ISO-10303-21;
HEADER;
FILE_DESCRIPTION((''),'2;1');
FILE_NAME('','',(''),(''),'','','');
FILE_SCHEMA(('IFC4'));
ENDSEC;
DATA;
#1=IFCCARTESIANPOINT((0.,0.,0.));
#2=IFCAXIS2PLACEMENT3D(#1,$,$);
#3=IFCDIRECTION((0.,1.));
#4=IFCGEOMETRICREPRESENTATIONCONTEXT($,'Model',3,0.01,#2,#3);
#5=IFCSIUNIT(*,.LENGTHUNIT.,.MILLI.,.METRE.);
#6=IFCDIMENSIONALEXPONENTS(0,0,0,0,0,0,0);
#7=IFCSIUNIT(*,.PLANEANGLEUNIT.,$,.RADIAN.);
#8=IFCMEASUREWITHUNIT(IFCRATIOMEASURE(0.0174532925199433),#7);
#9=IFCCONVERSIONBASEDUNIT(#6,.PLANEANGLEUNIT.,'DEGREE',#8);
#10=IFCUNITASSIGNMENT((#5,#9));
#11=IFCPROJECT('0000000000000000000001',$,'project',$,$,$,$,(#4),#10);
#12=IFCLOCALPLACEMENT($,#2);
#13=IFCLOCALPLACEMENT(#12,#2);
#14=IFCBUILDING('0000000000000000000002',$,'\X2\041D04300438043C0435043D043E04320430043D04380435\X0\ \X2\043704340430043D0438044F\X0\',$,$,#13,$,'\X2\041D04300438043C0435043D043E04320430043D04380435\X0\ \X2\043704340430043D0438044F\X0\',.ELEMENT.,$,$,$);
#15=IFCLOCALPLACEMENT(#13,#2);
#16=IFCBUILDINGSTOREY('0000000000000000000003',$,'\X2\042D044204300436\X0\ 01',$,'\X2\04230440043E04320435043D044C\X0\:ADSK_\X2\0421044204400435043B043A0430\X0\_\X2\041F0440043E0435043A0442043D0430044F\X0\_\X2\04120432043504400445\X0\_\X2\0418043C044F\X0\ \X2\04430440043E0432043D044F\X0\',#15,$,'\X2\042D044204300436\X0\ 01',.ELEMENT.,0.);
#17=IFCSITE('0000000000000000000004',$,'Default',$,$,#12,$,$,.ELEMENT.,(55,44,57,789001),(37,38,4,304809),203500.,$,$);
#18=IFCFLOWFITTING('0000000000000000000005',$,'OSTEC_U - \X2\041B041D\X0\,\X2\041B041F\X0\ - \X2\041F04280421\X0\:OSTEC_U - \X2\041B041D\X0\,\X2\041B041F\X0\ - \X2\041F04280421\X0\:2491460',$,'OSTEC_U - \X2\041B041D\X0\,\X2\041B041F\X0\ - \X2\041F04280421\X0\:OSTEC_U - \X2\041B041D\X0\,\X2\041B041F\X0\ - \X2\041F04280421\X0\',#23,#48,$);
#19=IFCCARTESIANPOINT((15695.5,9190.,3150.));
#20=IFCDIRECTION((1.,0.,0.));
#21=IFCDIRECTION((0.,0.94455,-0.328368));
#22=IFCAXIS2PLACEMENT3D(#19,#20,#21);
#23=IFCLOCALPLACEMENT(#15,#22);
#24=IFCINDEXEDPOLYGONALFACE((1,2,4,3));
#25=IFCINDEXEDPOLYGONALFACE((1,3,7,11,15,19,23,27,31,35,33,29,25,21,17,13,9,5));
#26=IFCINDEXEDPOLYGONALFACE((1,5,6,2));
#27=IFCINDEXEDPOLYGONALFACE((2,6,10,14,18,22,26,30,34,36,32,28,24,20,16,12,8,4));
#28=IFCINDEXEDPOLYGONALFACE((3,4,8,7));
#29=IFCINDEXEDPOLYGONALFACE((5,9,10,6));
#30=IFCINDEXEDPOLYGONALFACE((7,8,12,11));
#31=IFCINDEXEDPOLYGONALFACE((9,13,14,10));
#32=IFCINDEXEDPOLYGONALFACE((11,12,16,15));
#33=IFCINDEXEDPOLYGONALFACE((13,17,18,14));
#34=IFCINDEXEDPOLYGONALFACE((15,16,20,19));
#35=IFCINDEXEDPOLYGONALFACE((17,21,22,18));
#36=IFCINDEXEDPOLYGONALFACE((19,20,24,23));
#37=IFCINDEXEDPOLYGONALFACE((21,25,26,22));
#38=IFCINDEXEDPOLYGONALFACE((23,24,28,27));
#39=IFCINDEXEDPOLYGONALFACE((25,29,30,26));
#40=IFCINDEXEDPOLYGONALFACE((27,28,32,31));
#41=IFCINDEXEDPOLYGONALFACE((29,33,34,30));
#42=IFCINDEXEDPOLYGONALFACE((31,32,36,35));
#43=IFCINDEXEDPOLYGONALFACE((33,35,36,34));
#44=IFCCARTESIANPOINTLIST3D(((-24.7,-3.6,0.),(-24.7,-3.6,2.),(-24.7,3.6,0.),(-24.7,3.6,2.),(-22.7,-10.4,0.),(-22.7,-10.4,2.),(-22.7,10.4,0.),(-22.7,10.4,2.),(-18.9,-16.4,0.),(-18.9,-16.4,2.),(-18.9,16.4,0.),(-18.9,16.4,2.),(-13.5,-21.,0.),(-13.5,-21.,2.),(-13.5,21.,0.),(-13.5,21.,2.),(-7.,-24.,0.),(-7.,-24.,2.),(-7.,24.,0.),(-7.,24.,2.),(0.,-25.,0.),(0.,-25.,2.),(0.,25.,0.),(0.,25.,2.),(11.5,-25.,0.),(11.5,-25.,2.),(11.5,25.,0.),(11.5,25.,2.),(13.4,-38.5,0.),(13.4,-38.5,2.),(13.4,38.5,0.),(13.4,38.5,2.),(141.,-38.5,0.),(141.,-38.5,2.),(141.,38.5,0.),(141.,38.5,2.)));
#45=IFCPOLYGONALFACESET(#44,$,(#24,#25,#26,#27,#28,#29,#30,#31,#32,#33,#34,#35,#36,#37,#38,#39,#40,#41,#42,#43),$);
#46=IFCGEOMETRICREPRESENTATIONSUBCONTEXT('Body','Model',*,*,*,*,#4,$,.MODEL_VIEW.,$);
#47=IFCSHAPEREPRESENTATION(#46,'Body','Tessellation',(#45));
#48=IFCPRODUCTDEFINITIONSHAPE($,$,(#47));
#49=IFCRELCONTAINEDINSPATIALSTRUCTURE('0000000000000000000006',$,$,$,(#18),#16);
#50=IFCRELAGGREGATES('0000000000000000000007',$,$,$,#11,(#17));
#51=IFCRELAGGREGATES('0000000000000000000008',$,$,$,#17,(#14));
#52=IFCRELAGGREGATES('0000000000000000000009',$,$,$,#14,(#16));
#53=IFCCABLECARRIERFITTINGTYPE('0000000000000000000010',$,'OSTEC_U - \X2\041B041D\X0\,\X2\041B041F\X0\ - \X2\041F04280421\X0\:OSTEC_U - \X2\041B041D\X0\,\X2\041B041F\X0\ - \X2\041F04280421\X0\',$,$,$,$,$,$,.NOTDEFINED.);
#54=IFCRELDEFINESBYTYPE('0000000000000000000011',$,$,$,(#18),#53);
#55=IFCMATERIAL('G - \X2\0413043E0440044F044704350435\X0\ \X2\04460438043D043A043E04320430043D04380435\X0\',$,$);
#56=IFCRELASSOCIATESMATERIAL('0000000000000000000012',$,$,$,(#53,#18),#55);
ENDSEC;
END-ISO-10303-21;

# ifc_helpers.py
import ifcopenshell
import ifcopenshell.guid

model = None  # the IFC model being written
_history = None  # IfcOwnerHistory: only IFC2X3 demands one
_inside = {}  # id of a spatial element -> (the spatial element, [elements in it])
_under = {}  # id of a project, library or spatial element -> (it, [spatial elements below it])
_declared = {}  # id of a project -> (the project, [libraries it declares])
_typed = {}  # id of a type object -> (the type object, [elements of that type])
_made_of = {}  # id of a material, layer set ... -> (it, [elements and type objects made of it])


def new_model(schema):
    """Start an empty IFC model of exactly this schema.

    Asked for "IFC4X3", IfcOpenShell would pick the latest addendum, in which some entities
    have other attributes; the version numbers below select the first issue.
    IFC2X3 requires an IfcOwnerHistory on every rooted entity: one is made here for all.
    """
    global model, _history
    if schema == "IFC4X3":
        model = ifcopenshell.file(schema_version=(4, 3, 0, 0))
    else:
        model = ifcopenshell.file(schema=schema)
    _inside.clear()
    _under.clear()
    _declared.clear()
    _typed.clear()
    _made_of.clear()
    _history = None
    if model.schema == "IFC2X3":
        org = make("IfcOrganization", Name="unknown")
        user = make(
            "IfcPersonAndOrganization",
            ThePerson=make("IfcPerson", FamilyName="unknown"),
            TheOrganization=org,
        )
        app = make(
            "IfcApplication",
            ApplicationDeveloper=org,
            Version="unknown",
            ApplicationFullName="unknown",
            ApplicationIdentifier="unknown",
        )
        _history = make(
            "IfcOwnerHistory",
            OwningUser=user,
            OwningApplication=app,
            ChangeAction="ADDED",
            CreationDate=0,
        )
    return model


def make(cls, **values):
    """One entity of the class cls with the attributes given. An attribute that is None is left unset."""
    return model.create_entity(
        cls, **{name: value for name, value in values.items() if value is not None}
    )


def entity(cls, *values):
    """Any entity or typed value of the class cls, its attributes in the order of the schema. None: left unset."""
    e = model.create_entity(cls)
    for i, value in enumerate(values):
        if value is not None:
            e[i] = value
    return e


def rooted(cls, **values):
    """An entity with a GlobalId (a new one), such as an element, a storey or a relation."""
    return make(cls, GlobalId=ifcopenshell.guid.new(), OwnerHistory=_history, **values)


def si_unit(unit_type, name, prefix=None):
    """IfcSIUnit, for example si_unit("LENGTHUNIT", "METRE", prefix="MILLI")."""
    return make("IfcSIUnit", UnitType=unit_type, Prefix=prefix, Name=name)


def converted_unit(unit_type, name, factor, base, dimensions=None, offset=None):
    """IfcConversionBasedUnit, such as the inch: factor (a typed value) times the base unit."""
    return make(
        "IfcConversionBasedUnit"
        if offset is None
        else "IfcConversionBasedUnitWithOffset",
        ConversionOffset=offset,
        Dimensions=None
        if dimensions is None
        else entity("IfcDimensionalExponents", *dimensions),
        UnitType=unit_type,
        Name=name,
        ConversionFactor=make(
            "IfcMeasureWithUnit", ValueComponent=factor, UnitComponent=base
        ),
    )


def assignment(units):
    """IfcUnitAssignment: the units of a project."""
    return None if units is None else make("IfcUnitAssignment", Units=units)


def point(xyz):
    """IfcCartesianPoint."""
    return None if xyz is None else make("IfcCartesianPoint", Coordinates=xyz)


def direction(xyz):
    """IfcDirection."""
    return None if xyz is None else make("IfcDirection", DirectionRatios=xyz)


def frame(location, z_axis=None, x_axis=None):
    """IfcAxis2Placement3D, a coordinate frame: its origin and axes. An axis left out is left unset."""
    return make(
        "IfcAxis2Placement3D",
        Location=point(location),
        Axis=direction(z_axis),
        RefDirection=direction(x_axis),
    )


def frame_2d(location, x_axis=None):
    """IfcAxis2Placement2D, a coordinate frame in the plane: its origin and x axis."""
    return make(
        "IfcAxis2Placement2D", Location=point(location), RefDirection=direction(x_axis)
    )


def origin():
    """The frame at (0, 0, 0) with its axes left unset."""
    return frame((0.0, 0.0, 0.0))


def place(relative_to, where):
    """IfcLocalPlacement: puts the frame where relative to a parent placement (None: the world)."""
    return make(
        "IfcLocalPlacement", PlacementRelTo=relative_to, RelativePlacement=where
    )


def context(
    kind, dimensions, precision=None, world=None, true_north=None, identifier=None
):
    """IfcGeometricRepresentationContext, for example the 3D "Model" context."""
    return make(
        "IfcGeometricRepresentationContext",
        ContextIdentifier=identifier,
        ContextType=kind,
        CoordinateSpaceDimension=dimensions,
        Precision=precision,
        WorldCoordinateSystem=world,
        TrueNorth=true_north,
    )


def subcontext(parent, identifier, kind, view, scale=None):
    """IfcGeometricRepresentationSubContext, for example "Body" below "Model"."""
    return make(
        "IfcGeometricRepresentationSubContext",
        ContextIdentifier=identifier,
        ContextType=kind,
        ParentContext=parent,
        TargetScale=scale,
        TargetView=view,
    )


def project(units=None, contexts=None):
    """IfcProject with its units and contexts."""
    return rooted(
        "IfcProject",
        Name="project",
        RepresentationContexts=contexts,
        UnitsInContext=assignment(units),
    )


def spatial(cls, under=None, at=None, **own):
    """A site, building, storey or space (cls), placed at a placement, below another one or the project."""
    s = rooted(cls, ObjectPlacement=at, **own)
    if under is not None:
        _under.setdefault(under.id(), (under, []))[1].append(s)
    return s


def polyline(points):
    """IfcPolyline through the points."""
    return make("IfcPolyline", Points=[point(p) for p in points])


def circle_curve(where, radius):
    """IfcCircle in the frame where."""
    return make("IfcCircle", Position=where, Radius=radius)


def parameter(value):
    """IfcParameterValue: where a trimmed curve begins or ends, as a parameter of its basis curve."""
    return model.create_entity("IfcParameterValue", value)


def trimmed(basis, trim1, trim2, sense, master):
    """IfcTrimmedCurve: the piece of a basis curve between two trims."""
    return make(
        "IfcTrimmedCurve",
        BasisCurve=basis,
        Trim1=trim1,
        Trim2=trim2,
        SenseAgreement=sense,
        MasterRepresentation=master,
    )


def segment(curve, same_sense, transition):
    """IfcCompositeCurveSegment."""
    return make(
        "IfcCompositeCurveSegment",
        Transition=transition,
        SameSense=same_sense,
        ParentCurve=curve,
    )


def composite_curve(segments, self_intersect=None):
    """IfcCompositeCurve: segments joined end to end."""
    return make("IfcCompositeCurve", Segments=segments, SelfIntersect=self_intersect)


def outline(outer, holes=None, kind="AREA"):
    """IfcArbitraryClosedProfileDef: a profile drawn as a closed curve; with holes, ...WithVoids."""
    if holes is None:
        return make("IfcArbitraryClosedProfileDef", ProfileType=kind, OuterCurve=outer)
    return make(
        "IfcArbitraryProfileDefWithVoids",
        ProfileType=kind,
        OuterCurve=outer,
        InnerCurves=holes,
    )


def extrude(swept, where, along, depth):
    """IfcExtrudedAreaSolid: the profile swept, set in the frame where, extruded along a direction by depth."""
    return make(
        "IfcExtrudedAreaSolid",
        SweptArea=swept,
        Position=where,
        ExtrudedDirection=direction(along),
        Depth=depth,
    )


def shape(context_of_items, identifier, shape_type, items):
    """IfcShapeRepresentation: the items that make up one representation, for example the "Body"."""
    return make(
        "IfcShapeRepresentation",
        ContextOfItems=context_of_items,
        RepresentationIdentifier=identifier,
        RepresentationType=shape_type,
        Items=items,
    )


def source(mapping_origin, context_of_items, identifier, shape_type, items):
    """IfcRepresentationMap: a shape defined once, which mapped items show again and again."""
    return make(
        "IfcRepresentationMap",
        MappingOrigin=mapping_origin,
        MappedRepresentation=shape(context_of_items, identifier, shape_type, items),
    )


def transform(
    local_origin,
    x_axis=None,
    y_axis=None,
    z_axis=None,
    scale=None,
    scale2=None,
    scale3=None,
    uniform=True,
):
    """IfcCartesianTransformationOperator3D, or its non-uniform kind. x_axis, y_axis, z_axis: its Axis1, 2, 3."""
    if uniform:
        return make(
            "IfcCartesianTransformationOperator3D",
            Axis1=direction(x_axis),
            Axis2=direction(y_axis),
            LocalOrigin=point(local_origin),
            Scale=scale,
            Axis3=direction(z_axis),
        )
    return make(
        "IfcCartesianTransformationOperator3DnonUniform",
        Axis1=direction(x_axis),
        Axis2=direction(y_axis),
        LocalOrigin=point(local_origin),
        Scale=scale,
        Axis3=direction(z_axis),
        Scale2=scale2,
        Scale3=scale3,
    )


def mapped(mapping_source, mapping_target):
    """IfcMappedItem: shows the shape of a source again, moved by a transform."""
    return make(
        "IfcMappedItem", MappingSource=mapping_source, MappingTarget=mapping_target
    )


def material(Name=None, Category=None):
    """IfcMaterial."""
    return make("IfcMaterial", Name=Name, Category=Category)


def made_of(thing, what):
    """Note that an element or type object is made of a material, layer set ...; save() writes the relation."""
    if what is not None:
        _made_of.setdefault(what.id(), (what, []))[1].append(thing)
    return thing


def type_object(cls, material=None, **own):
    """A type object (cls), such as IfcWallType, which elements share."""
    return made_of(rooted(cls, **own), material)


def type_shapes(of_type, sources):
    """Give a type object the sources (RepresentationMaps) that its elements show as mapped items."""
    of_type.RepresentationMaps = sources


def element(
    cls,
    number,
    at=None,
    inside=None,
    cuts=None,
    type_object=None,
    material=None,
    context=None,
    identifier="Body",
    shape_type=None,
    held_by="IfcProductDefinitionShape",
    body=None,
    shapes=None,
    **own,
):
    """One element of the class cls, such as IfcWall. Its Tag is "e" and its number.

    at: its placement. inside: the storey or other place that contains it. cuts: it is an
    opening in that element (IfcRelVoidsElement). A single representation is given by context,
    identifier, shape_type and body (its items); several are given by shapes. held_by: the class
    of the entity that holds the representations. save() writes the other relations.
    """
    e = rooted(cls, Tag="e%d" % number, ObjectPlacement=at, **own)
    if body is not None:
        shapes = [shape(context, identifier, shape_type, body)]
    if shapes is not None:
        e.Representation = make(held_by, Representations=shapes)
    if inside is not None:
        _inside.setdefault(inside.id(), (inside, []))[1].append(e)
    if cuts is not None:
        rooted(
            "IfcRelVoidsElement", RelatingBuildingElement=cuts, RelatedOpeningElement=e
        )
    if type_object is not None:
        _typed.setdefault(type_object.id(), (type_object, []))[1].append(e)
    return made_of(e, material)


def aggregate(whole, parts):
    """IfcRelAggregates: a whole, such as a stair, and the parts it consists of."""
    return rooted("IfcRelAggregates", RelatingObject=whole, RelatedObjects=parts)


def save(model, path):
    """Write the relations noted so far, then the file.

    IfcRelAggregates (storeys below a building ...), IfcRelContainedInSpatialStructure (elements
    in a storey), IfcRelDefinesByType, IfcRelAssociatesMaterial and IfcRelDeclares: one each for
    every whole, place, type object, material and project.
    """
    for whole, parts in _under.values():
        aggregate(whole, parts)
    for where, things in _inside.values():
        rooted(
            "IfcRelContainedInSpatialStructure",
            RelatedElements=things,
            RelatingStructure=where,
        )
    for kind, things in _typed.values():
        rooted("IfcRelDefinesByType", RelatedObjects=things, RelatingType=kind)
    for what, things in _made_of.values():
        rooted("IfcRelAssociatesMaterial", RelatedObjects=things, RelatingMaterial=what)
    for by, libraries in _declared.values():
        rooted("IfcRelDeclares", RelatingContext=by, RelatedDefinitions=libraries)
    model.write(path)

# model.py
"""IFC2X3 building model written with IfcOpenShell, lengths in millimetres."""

from ifc_helpers import new_model, entity, si_unit, converted_unit, direction, frame, frame_2d, origin, place, context, subcontext, project, spatial, polyline, circle_curve, parameter, trimmed, segment, composite_curve, outline, extrude, source, transform, mapped, material, type_object, type_shapes, element, save


model = new_model("IFC2X3")

# Units and contexts
model_context = context("Model", 3, precision=0.01, world=origin(), true_north=direction((0.0, 1.0)))
body_context = subcontext(model_context, "Body", "Model", "MODEL_VIEW")
ifc_project = project(units=[si_unit("LENGTHUNIT", "METRE", prefix="MILLI"), converted_unit("PLANEANGLEUNIT", "DEGREE", entity("IfcRatioMeasure", 0.0174532925199433), si_unit("PLANEANGLEUNIT", "RADIAN"), dimensions=[0, 0, 0, 0, 0, 0, 0])], contexts=[model_context])

# Site, building, storey
site_placement = place(None, origin())
site = spatial("IfcSite", under=ifc_project, at=site_placement, Name="Default", CompositionType="ELEMENT", RefLatitude=(55, 44, 57, 789001), RefLongitude=(37, 38, 4, 304809), RefElevation=203500.0)
building_placement = place(site_placement, origin())
building = spatial("IfcBuilding", under=site, at=building_placement, Name="Наименование здания", LongName="Наименование здания", CompositionType="ELEMENT")
storey_placement = place(building_placement, origin())
storey = spatial("IfcBuildingStorey", under=building, at=storey_placement, Name="Этаж 01", ObjectType="Уровень:ADSK_Стрелка_Проектная_Вверх_Имя уровня", LongName="Этаж 01", CompositionType="ELEMENT", Elevation=0.0)

# Flow fitting
ifc_material = material(Name="G - Горячее цинкование")
cable_carrier_fitting_type_1 = type_object("IfcCableCarrierFittingType", Name="OSTEC_U - ЛН,ЛП - ПШС:OSTEC_U - ЛН,ЛП - ПШС", PredefinedType="NOTDEFINED", material=ifc_material)
shared_shape_1 = source(origin(), body_context, "Body", "SweptSolid", [
    extrude(outline(composite_curve([segment(trimmed(circle_curve(frame_2d((-41.5, 0.0), x_axis=(1.0, 0.0)), 25.0), [parameter(90.0)], [parameter(270.0)], True, "PARAMETER"), True, "CONTINUOUS"), segment(polyline([(-41.5, -25.0), (-30.0, -25.0)]), True, "CONTINUOUS"), segment(polyline([(-30.0, -25.0), (-28.1, -38.5)]), True, "CONTINUOUS"), segment(polyline([(-28.1, -38.5), (99.5, -38.5)]), True, "CONTINUOUS"), segment(polyline([(99.5, -38.5), (99.5, 38.5)]), True, "CONTINUOUS"), segment(polyline([(99.5, 38.5), (-28.1, 38.5)]), True, "CONTINUOUS"), segment(polyline([(-28.1, 38.5), (-30.0, 25.0)]), True, "CONTINUOUS"), segment(polyline([(-30.0, 25.0), (-41.5, 25.0)]), True, "CONTINUOUS")], self_intersect=False)), frame((41.5, 0.0, 0.0)), (0.0, 0.0, 1.0), 2.0),
])
type_shapes(cable_carrier_fitting_type_1, [shared_shape_1])
for number, where, z_axis, x_axis, name in (
    (1, (15695.5, 9190.0, 3150.0), (1.0, 0.0, 0.0), (0.0, 0.94455, -0.328368), "OSTEC_U - ЛН,ЛП - ПШС:OSTEC_U - ЛН,ЛП - ПШС:2491460"),
):
    element("IfcFlowFitting", number, at=place(storey_placement, frame(where, z_axis=z_axis, x_axis=x_axis)), inside=storey, type_object=cable_carrier_fitting_type_1, material=ifc_material, Name=name, ObjectType="OSTEC_U - ЛН,ЛП - ПШС:OSTEC_U - ЛН,ЛП - ПШС", context=body_context, shape_type="MappedRepresentation", body=[
        mapped(shared_shape_1, transform((0.0, 0.0, 0.0), scale=1.0)),
    ])

save(model, "model.ifc")
